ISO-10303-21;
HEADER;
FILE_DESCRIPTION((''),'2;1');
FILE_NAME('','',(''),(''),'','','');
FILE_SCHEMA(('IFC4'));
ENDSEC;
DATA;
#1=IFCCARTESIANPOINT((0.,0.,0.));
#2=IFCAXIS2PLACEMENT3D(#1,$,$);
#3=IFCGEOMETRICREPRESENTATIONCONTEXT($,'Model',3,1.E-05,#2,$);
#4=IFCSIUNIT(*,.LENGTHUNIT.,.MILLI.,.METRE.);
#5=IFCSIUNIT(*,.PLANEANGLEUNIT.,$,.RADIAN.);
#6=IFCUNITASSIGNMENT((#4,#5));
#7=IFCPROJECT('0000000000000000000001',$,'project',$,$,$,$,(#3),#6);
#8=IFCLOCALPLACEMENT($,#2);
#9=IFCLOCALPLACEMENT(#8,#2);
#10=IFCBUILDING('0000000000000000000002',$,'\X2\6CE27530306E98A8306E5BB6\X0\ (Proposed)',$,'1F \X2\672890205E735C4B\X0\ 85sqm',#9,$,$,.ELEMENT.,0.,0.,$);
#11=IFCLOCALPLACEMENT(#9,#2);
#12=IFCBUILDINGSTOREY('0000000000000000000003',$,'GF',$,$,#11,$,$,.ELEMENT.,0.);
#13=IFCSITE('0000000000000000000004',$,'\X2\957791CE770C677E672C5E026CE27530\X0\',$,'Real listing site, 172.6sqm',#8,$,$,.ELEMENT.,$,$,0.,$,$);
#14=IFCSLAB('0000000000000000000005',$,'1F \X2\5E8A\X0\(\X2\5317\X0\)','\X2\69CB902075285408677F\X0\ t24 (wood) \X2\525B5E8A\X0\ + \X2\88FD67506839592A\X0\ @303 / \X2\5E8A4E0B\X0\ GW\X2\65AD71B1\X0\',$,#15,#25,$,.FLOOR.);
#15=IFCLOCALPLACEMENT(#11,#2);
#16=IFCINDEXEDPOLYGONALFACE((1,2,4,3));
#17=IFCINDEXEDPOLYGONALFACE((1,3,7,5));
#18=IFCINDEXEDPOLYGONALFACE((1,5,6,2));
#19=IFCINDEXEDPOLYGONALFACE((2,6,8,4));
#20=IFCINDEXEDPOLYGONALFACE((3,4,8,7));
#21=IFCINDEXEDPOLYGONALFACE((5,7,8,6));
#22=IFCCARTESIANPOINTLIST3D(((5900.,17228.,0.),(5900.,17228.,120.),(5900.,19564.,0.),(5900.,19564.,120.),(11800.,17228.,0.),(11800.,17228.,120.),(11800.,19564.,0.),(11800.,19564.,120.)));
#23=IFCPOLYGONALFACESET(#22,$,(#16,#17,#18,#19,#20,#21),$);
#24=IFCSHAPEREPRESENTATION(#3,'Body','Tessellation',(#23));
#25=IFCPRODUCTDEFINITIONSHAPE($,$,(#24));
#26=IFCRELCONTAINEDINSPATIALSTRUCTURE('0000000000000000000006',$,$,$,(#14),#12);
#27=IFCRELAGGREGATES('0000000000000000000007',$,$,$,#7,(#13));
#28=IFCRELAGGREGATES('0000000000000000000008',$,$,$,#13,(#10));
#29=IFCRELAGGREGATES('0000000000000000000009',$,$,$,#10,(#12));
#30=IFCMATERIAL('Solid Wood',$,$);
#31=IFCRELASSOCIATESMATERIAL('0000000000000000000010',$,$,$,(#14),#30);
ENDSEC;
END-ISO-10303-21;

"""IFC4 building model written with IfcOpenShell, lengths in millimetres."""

from ifc_helpers import new_model, si_unit, frame, frame_2d, origin, place, context, project, spatial, rectangle, extrude, material, element, save


model = new_model("IFC4")

# Units and contexts
model_context = context("Model", 3, precision=1e-05, world=origin())
ifc_project = project(units=[si_unit("LENGTHUNIT", "METRE", prefix="MILLI"), si_unit("PLANEANGLEUNIT", "RADIAN")], contexts=[model_context])

# Site, building, storey
site_placement = place(None, origin())
site = spatial("IfcSite", under=ifc_project, at=site_placement, Name="長野県松本市波田", ObjectType="Real listing site, 172.6sqm", CompositionType="ELEMENT", RefElevation=0.0)
building_placement = place(site_placement, origin())
building = spatial("IfcBuilding", under=site, at=building_placement, Name="波田の風の家 (Proposed)", ObjectType="1F 木造平屋 85sqm", CompositionType="ELEMENT", ElevationOfRefHeight=0.0, ElevationOfTerrain=0.0)
storey_placement = place(building_placement, origin())
storey = spatial("IfcBuildingStorey", under=building, at=storey_placement, Name="GF", CompositionType="ELEMENT", Elevation=0.0)

# Slab
ifc_material_1 = material(Name="Solid Wood")
slab_1_placement = place(storey_placement, frame((2950.0, 8614.0, 0.0)))
element("IfcSlab", 1, at=slab_1_placement, inside=storey, material=ifc_material_1, Name="1F 床(北)", Description="構造用合板 t24 (wood) 剛床 + 製材根太 @303 / 床下 GW断熱", PredefinedType="FLOOR", context=model_context, shape_type="SweptSolid", body=[
    extrude(rectangle(XDim=5900.0, YDim=2336.0, at=frame_2d((2950.0, 1168.0))), frame((2950.0, 8614.0, 0.0)), (0.0, 0.0, 1.0), 120.0),
])

save(model, "model.ifc")
